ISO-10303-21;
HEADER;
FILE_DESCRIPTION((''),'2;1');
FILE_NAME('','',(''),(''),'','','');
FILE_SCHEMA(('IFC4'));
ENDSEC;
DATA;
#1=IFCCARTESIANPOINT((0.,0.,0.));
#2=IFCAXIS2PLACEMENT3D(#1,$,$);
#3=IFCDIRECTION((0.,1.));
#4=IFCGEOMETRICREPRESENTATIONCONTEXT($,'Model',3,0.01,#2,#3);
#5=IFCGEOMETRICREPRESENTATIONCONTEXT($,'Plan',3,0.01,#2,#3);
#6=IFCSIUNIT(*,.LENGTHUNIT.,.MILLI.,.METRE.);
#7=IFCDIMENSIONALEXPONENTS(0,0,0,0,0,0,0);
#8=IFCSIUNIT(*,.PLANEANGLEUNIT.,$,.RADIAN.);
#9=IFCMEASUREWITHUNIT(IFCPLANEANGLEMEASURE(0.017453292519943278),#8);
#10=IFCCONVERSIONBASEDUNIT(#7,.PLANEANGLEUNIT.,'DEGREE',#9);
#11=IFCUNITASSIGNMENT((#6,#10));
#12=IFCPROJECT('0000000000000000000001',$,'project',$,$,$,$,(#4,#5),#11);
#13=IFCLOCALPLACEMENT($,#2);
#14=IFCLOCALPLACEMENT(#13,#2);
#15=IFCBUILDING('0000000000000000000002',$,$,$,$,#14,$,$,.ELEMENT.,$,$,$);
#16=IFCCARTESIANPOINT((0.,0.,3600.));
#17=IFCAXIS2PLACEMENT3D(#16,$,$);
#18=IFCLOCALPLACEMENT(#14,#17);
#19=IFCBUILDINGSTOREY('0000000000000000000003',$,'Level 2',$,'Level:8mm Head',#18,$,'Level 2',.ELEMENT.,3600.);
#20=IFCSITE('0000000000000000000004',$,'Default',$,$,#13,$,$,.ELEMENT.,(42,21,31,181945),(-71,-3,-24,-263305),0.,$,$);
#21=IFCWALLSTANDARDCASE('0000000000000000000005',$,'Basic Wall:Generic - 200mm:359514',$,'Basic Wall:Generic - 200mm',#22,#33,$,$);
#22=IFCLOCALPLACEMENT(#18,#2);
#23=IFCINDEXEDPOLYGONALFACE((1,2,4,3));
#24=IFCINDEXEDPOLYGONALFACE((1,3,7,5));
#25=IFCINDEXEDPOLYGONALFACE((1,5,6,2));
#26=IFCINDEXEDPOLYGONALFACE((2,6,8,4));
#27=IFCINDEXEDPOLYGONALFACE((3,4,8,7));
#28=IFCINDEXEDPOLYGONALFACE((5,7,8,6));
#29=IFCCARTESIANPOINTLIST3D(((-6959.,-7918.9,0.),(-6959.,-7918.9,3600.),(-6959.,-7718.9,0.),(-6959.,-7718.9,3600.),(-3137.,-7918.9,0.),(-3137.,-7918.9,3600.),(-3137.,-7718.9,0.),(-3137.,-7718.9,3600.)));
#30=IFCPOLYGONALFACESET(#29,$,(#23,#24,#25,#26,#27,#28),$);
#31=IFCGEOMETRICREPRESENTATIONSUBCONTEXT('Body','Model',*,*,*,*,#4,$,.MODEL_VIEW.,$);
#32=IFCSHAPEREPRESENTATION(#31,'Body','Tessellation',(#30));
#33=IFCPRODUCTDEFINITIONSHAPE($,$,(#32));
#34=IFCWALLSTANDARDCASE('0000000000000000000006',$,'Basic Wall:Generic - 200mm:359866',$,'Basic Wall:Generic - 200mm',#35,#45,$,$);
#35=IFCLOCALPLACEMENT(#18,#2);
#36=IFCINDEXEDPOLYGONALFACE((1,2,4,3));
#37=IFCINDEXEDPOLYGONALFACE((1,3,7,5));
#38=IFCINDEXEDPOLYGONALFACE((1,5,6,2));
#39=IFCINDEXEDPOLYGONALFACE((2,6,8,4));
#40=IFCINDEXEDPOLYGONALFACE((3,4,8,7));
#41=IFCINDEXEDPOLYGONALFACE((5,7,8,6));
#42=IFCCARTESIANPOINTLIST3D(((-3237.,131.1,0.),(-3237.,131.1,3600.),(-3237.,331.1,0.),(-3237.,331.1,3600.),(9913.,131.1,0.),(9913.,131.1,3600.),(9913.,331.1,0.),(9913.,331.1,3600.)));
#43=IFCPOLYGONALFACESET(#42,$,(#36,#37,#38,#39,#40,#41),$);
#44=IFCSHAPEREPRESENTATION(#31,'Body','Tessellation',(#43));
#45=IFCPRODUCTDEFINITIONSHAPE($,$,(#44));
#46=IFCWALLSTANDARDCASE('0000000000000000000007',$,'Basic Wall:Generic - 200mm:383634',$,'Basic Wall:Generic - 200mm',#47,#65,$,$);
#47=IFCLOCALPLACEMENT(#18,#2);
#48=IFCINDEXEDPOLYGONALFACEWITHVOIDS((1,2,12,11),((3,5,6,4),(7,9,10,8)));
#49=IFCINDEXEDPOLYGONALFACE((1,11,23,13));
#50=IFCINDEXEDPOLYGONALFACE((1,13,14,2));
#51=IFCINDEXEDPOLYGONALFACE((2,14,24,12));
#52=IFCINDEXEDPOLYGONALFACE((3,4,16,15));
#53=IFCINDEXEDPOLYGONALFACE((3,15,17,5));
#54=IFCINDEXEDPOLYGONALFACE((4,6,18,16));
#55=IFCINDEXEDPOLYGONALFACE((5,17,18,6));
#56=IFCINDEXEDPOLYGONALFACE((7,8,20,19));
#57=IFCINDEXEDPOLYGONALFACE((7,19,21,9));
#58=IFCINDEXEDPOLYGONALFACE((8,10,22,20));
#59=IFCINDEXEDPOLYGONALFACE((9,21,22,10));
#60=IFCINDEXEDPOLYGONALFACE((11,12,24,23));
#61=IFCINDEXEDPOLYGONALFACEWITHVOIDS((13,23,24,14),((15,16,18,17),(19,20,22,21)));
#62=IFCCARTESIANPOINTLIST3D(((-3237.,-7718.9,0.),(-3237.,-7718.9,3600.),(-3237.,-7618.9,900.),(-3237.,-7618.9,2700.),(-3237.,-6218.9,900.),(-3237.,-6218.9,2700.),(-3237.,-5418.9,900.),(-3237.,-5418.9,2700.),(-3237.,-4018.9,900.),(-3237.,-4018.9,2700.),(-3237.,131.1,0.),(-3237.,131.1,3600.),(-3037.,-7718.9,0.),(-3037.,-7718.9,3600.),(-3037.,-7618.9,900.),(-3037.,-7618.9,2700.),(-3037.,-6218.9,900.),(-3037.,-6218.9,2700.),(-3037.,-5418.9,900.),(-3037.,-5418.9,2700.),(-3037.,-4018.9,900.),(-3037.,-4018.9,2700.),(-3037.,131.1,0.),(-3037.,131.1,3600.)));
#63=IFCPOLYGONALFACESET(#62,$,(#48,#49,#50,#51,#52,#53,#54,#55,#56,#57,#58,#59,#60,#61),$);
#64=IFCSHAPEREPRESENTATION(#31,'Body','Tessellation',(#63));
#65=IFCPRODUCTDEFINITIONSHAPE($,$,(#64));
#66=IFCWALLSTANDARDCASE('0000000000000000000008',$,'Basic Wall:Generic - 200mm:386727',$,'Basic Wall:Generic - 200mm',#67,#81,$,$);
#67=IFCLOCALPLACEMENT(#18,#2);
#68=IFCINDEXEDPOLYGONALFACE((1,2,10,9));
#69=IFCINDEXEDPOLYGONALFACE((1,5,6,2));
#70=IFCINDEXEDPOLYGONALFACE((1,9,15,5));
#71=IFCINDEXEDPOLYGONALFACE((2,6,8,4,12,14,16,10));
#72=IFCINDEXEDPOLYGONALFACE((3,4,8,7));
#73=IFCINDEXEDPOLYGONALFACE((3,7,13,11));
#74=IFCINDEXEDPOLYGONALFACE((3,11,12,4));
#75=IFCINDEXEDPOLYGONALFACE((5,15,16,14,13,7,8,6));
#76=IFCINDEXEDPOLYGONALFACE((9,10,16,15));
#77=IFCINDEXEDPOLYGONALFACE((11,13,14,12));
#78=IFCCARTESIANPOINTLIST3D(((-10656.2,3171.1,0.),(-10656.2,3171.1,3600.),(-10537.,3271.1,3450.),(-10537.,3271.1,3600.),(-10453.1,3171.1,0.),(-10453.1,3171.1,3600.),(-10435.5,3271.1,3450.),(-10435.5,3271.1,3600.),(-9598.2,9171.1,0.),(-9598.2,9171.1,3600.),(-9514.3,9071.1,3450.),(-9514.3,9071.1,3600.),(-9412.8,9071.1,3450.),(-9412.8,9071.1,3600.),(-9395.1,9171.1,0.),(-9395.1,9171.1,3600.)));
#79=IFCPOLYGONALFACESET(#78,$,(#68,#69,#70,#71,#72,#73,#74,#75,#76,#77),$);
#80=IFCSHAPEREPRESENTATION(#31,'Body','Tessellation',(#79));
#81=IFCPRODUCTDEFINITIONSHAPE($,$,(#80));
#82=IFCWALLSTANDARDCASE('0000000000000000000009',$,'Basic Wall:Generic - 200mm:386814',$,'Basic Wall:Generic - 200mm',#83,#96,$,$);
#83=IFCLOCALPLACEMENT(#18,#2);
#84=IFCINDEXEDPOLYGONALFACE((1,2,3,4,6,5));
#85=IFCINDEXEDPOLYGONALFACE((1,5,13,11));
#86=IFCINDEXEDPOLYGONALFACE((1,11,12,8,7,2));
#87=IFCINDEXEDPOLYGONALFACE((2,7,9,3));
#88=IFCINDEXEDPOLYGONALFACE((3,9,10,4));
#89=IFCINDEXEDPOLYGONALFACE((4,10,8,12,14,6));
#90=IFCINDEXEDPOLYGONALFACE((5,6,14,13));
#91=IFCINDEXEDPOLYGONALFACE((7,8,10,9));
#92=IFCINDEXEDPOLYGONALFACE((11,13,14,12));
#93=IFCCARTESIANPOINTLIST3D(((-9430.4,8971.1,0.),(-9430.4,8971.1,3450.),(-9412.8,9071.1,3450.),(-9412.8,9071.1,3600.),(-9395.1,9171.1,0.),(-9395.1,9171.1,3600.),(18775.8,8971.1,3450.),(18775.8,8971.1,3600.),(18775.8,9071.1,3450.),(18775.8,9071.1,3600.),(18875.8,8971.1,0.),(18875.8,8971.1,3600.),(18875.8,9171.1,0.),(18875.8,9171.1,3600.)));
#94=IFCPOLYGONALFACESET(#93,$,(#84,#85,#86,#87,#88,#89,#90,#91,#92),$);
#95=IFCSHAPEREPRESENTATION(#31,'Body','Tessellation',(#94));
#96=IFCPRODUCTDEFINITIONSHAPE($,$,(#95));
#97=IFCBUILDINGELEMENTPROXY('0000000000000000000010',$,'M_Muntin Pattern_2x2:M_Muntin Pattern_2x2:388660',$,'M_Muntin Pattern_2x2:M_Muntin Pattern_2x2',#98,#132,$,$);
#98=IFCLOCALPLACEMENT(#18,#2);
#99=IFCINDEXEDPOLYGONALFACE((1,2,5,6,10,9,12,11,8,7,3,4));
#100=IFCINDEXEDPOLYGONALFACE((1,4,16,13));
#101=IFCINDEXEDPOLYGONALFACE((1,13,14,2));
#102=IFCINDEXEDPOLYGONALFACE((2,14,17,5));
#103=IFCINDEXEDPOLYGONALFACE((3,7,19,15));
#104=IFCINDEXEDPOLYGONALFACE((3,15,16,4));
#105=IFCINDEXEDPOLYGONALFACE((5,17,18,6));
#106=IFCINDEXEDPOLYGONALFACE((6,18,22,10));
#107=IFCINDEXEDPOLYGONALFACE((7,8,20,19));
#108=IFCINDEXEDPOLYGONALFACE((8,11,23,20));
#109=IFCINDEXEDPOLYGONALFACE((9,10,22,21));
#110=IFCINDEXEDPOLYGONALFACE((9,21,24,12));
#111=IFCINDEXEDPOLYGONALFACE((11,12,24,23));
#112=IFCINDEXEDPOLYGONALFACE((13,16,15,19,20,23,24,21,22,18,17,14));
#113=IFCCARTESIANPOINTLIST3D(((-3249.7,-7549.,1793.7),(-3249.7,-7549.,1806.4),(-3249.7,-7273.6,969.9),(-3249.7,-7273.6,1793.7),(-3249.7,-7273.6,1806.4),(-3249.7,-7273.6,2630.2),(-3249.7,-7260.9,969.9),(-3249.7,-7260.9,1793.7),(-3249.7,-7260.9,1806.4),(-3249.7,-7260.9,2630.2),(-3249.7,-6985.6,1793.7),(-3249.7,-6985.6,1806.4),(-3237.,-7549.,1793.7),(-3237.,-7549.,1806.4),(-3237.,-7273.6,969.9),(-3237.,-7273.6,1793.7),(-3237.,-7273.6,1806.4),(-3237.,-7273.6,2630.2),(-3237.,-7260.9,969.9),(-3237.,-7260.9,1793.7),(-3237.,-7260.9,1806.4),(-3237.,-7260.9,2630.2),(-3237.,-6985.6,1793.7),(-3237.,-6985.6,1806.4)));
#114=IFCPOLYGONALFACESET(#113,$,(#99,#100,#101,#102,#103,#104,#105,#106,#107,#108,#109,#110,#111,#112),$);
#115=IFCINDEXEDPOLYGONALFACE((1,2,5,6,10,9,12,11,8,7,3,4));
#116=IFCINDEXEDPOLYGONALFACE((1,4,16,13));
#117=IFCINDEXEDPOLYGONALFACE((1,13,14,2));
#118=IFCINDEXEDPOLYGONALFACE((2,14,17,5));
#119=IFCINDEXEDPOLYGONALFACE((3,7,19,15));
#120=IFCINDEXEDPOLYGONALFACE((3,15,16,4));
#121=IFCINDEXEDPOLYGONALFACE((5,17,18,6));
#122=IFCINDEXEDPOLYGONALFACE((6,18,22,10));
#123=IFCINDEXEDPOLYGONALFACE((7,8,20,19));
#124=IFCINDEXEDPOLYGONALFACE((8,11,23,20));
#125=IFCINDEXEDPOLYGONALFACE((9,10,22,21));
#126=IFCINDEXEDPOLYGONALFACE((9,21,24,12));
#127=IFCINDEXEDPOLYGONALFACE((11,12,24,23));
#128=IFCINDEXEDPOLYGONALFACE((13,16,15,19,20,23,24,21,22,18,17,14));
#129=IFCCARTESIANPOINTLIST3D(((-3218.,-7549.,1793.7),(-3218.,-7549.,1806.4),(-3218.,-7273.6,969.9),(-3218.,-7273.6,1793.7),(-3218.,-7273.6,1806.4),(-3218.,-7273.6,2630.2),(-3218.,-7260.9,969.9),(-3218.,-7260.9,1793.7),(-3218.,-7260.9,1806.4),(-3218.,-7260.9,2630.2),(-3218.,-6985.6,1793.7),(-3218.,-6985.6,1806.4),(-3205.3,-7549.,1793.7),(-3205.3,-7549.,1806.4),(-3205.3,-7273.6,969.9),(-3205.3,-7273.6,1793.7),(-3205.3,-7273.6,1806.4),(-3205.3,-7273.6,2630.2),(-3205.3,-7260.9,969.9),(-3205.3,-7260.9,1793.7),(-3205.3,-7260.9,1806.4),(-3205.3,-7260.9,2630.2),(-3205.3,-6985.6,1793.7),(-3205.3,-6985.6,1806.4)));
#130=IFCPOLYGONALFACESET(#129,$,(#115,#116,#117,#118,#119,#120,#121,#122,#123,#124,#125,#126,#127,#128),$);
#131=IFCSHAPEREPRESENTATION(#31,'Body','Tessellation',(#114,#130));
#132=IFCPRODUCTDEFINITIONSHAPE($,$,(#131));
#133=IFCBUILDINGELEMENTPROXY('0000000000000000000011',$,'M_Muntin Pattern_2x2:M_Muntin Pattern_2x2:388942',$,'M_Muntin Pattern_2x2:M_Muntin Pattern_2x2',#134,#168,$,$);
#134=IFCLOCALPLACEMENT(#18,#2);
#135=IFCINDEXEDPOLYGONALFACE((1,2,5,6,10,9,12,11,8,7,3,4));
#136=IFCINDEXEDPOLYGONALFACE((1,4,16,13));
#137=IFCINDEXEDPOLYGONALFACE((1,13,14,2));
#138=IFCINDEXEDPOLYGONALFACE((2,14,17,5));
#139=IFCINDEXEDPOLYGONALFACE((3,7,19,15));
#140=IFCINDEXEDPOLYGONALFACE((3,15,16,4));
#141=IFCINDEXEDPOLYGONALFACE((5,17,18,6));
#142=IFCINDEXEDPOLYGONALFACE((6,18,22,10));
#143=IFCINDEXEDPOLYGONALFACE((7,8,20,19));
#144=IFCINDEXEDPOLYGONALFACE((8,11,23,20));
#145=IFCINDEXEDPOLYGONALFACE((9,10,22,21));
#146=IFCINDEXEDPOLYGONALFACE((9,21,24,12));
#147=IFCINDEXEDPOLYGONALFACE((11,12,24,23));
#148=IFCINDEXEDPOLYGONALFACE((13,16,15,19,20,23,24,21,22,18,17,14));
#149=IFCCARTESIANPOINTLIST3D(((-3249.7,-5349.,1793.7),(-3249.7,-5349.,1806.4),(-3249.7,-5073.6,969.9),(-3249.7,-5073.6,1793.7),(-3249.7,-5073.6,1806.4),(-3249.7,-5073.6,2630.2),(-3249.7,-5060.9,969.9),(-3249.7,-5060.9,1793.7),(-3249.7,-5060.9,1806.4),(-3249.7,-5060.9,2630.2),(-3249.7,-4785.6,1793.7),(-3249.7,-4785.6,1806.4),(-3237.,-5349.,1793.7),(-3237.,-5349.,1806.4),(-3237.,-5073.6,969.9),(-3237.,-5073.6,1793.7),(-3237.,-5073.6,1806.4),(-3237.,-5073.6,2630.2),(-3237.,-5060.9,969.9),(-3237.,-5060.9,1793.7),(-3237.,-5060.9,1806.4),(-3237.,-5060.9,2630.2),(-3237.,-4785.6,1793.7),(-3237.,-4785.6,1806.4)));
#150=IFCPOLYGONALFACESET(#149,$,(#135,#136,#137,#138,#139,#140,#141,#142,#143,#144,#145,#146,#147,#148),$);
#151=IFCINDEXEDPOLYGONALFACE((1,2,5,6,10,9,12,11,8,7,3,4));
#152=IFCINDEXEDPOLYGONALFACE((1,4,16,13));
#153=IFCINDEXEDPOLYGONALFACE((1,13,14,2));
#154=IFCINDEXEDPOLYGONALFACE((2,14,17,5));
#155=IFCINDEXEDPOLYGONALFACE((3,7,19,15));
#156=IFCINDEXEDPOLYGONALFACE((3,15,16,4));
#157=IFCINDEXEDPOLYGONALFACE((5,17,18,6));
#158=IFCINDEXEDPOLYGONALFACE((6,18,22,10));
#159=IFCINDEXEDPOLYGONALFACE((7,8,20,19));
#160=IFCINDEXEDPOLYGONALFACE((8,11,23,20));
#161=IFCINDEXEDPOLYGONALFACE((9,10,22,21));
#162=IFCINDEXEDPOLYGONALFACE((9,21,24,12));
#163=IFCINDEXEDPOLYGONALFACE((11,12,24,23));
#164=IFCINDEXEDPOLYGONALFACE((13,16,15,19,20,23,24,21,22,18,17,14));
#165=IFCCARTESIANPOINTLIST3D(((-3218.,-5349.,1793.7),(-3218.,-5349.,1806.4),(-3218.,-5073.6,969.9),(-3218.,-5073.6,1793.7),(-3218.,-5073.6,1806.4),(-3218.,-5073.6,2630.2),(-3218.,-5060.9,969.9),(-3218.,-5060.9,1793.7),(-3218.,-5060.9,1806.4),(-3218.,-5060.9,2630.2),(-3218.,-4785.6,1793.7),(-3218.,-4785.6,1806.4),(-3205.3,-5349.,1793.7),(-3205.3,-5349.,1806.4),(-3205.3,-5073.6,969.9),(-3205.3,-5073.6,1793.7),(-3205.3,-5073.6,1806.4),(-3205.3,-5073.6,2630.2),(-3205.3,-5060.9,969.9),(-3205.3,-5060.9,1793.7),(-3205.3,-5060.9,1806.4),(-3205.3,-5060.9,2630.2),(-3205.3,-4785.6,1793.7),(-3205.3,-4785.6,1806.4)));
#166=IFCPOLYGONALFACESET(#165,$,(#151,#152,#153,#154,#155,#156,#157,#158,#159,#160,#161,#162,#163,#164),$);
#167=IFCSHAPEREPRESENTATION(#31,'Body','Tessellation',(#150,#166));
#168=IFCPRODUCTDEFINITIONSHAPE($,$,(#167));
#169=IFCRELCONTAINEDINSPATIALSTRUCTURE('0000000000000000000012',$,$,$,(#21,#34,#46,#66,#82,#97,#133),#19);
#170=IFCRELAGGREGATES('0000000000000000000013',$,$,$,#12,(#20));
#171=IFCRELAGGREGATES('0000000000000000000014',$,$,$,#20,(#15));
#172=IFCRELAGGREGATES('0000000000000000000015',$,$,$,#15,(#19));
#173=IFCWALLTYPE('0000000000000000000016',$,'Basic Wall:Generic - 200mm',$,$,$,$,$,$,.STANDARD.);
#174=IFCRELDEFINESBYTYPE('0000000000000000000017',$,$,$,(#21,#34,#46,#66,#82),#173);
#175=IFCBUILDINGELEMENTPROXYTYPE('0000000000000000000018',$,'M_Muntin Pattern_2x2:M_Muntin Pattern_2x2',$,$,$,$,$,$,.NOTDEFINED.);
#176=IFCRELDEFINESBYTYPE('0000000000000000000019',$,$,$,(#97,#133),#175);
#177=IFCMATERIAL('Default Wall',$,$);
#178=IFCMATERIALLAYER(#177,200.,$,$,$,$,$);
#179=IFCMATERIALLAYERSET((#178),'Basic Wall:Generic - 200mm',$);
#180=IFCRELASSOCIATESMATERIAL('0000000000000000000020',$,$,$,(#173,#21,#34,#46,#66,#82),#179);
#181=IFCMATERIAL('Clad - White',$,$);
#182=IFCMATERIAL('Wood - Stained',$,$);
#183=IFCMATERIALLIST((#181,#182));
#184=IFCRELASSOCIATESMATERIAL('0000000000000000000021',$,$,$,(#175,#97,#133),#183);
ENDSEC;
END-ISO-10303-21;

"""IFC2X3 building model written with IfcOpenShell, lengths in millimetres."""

from ifc_helpers import new_model, entity, si_unit, converted_unit, direction, frame, frame_2d, origin, place, context, subcontext, project, spatial, polyline, rectangle, outline, extrude, clip, bounded_halfspace, source, transform, mapped, material, material_list, layer, layer_set, layer_usage, type_object, type_shapes, element, save


model = new_model("IFC2X3")

# Units and contexts
model_context = context("Model", 3, precision=0.01, world=origin(), true_north=direction((0.0, 1.0)))
plan_context = context("Plan", 3, precision=0.01, world=origin(), true_north=direction((0.0, 1.0)))
body_context = subcontext(model_context, "Body", "Model", "MODEL_VIEW")
ifc_project = project(units=[si_unit("LENGTHUNIT", "METRE", prefix="MILLI"), converted_unit("PLANEANGLEUNIT", "DEGREE", entity("IfcPlaneAngleMeasure", 0.017453292519943278), si_unit("PLANEANGLEUNIT", "RADIAN"), dimensions=[0, 0, 0, 0, 0, 0, 0])], contexts=[model_context, plan_context])

# Site, building, storey
site_placement = place(None, origin())
site = spatial("IfcSite", under=ifc_project, at=site_placement, Name="Default", CompositionType="ELEMENT", RefLatitude=(42, 21, 31, 181945), RefLongitude=(-71, -3, -24, -263305), RefElevation=0.0)
building_placement = place(site_placement, origin())
building = spatial("IfcBuilding", under=site, at=building_placement, CompositionType="ELEMENT")
storey_placement = place(building_placement, frame((0.0, 0.0, 3600.0)))
storey = spatial("IfcBuildingStorey", under=building, at=storey_placement, Name="Level 2", ObjectType="Level:8mm Head", LongName="Level 2", CompositionType="ELEMENT", Elevation=3600.0)

# Walls
ifc_material_1 = material(Name="Default Wall")
ifc_layer_1 = layer(ifc_material_1, 200.0)
ifc_layer_set_1 = layer_set([ifc_layer_1], Name="Basic Wall:Generic - 200mm")
ifc_layer_usage_1 = layer_usage(ifc_layer_set_1, "AXIS2", "NEGATIVE", 100.0)
wall_type = type_object("IfcWallType", Name="Basic Wall:Generic - 200mm", PredefinedType="STANDARD", material=ifc_layer_set_1)
wall_1_placement = place(storey_placement, frame((-6959.0, -7818.9, 0.0)))
element("IfcWallStandardCase", 1, at=wall_1_placement, inside=storey, type_object=wall_type, material=ifc_layer_usage_1, Name="Basic Wall:Generic - 200mm:359514", ObjectType="Basic Wall:Generic - 200mm", context=body_context, shape_type="SweptSolid", body=[
    extrude(rectangle(XDim=3822.0, YDim=200.0, at=frame_2d((1911.0, 0.0), x_axis=(-1.0, 0.0))), origin(), (0.0, 0.0, 1.0), 3600.0),
])
ifc_layer_usage_2 = layer_usage(ifc_layer_set_1, "AXIS2", "POSITIVE", -100.0)
wall_2_placement = place(storey_placement, frame((-3237.0, 231.1, 0.0)))
element("IfcWallStandardCase", 2, at=wall_2_placement, inside=storey, type_object=wall_type, material=ifc_layer_usage_2, Name="Basic Wall:Generic - 200mm:359866", ObjectType="Basic Wall:Generic - 200mm", context=body_context, shape_type="SweptSolid", body=[
    extrude(rectangle(XDim=13150.0, YDim=200.0, at=frame_2d((6575.0, 0.0), x_axis=(-1.0, 0.0))), origin(), (0.0, 0.0, 1.0), 3600.0),
])

# Wall, openings
ifc_layer_usage_3 = layer_usage(ifc_layer_set_1, "AXIS2", "NEGATIVE", 100.0)
wall_3_placement = place(storey_placement, frame((-3137.0, 131.1, 0.0), z_axis=(0.0, 0.0, 1.0), x_axis=(0.0, -1.0, 0.0)))
wall_3 = element("IfcWallStandardCase", 3, at=wall_3_placement, inside=storey, type_object=wall_type, material=ifc_layer_usage_3, Name="Basic Wall:Generic - 200mm:383634", ObjectType="Basic Wall:Generic - 200mm", context=body_context, shape_type="SweptSolid", body=[
    extrude(rectangle(XDim=7850.0, YDim=200.0, at=frame_2d((3925.0, 0.0), x_axis=(-1.0, 0.0))), origin(), (0.0, 0.0, 1.0), 3600.0),
])
opening_1_placement = place(wall_3_placement, frame((7750.0, 100.0, 900.0)))
element("IfcOpeningElement", 4, at=opening_1_placement, cuts=wall_3, ObjectType="Opening", context=body_context, shape_type="SweptSolid", body=[
    extrude(rectangle(XDim=1800.0, YDim=1400.0, at=frame_2d((900.0, 700.0), x_axis=(-1.0, 0.0))), frame((0.0, 0.0, 0.0), z_axis=(0.0, -1.0, 0.0), x_axis=(0.0, 0.0, 1.0)), (0.0, 0.0, 1.0), 200.0),
])
opening_2_placement = place(wall_3_placement, frame((5550.0, 100.0, 900.0)))
element("IfcOpeningElement", 5, at=opening_2_placement, cuts=wall_3, ObjectType="Opening", context=body_context, shape_type="SweptSolid", body=[
    extrude(rectangle(XDim=1800.0, YDim=1400.0, at=frame_2d((900.0, 700.0), x_axis=(-1.0, 0.0))), frame((0.0, 0.0, 0.0), z_axis=(0.0, -1.0, 0.0), x_axis=(0.0, 0.0, 1.0)), (0.0, 0.0, 1.0), 200.0),
])

# Walls
ifc_layer_usage_4 = layer_usage(ifc_layer_set_1, "AXIS2", "NEGATIVE", 100.0)
wall_4_placement = place(storey_placement, frame((-10557.7, 3153.8, 0.0), z_axis=(0.0, 0.0, 1.0), x_axis=(0.173648, 0.984808, 0.0)))
element("IfcWallStandardCase", 6, at=wall_4_placement, inside=storey, type_object=wall_type, material=ifc_layer_usage_4, Name="Basic Wall:Generic - 200mm:386727", ObjectType="Basic Wall:Generic - 200mm", context=body_context, shape_type="Clipping", body=[
    clip(extrude(outline(polyline([(6127.8, -100.0), (6092.6, 100.0), (0.0, 100.0), (35.3, -100.0), (238.4, -100.0), (5924.7, -100.0), (6127.8, -100.0)])), origin(), (0.0, 0.0, 1.0), 3600.0), bounded_halfspace(frame((136.8, -100.0, 3450.0), z_axis=(0.0, 0.0, -1.0), x_axis=(-0.984808, -0.173648, 0.0)), True, frame((136.8, -100.0, 3450.0)), polyline([(0.0, 0.0), (101.5, 0.0), (5787.9, 0.0), (5889.5, 0.0), (5871.8, 100.0), (-17.6, 100.0), (0.0, 0.0)]))),
])
ifc_layer_usage_5 = layer_usage(ifc_layer_set_1, "AXIS2", "NEGATIVE", 100.0)
wall_5_placement = place(storey_placement, frame((-9430.4, 9071.1, 0.0)))
element("IfcWallStandardCase", 7, at=wall_5_placement, inside=storey, type_object=wall_type, material=ifc_layer_usage_5, Name="Basic Wall:Generic - 200mm:386814", ObjectType="Basic Wall:Generic - 200mm", context=body_context, shape_type="Clipping", body=[
    clip(extrude(outline(polyline([(28306.2, -100.0), (28306.2, 100.0), (35.3, 100.0), (0.0, -100.0), (28106.2, -100.0), (28306.2, -100.0)])), origin(), (0.0, 0.0, 1.0), 3600.0), bounded_halfspace(frame((0.0, -100.0, 3450.0), z_axis=(0.0, 0.0, -1.0), x_axis=(0.0, -1.0, 0.0)), True, frame((0.0, -100.0, 3450.0)), polyline([(0.0, 0.0), (28106.2, 0.0), (28206.2, 0.0), (28206.2, 100.0), (17.6, 100.0), (0.0, 0.0)]))),
])

# Building element proxies
ifc_material_2 = material(Name="Clad - White")
ifc_material_3 = material(Name="Wood - Stained")
ifc_material_list = material_list([ifc_material_2, ifc_material_3])
building_element_proxy_type_1 = type_object("IfcBuildingElementProxyType", Name="M_Muntin Pattern_2x2:M_Muntin Pattern_2x2", PredefinedType="NOTDEFINED", material=ifc_material_list)
shared_shape_1 = source(origin(), body_context, "Body", "SweptSolid", [
    extrude(outline(polyline([(6.4, -6.4), (830.1, -6.4), (830.1, 6.3), (6.4, 6.3), (6.4, 281.7), (-6.3, 281.7), (-6.3, 6.3), (-830.2, 6.3), (-830.2, -6.4), (-6.3, -6.4), (-6.3, -281.7), (6.4, -281.7), (6.4, -6.4)])), frame((0.0, 9.5, 830.1), z_axis=(0.0, 1.0, 0.0), x_axis=(0.0, 0.0, 1.0)), (0.0, 0.0, 1.0), 12.7),
    extrude(outline(polyline([(6.4, -6.4), (830.2, -6.4), (830.2, 6.3), (6.4, 6.3), (6.4, 281.7), (-6.3, 281.7), (-6.3, 6.3), (-830.2, 6.3), (-830.2, -6.4), (-6.3, -6.4), (-6.3, -281.7), (6.4, -281.7), (6.4, -6.4)])), frame((0.0, -22.2, 830.2), z_axis=(0.0, 1.0, 0.0), x_axis=(0.0, 0.0, 1.0)), (0.0, 0.0, 1.0), 12.7),
])
type_shapes(building_element_proxy_type_1, [shared_shape_1])
for number, where, z_axis, x_axis, name in (
    (8, (-3227.5, -7267.3, 969.9), (0.0, 0.0, 1.0), (0.0, 1.0, 0.0), "M_Muntin Pattern_2x2:M_Muntin Pattern_2x2:388660"),
    (9, (-3227.5, -5067.3, 969.9), (0.0, 0.0, 1.0), (0.0, 1.0, 0.0), "M_Muntin Pattern_2x2:M_Muntin Pattern_2x2:388942"),
):
    element("IfcBuildingElementProxy", number, at=place(storey_placement, frame(where, z_axis=z_axis, x_axis=x_axis)), inside=storey, type_object=building_element_proxy_type_1, material=ifc_material_list, Name=name, ObjectType="M_Muntin Pattern_2x2:M_Muntin Pattern_2x2", context=body_context, shape_type="MappedRepresentation", body=[
        mapped(shared_shape_1, transform((0.0, 0.0, 0.0), scale=1.0)),
    ])

save(model, "model.ifc")
